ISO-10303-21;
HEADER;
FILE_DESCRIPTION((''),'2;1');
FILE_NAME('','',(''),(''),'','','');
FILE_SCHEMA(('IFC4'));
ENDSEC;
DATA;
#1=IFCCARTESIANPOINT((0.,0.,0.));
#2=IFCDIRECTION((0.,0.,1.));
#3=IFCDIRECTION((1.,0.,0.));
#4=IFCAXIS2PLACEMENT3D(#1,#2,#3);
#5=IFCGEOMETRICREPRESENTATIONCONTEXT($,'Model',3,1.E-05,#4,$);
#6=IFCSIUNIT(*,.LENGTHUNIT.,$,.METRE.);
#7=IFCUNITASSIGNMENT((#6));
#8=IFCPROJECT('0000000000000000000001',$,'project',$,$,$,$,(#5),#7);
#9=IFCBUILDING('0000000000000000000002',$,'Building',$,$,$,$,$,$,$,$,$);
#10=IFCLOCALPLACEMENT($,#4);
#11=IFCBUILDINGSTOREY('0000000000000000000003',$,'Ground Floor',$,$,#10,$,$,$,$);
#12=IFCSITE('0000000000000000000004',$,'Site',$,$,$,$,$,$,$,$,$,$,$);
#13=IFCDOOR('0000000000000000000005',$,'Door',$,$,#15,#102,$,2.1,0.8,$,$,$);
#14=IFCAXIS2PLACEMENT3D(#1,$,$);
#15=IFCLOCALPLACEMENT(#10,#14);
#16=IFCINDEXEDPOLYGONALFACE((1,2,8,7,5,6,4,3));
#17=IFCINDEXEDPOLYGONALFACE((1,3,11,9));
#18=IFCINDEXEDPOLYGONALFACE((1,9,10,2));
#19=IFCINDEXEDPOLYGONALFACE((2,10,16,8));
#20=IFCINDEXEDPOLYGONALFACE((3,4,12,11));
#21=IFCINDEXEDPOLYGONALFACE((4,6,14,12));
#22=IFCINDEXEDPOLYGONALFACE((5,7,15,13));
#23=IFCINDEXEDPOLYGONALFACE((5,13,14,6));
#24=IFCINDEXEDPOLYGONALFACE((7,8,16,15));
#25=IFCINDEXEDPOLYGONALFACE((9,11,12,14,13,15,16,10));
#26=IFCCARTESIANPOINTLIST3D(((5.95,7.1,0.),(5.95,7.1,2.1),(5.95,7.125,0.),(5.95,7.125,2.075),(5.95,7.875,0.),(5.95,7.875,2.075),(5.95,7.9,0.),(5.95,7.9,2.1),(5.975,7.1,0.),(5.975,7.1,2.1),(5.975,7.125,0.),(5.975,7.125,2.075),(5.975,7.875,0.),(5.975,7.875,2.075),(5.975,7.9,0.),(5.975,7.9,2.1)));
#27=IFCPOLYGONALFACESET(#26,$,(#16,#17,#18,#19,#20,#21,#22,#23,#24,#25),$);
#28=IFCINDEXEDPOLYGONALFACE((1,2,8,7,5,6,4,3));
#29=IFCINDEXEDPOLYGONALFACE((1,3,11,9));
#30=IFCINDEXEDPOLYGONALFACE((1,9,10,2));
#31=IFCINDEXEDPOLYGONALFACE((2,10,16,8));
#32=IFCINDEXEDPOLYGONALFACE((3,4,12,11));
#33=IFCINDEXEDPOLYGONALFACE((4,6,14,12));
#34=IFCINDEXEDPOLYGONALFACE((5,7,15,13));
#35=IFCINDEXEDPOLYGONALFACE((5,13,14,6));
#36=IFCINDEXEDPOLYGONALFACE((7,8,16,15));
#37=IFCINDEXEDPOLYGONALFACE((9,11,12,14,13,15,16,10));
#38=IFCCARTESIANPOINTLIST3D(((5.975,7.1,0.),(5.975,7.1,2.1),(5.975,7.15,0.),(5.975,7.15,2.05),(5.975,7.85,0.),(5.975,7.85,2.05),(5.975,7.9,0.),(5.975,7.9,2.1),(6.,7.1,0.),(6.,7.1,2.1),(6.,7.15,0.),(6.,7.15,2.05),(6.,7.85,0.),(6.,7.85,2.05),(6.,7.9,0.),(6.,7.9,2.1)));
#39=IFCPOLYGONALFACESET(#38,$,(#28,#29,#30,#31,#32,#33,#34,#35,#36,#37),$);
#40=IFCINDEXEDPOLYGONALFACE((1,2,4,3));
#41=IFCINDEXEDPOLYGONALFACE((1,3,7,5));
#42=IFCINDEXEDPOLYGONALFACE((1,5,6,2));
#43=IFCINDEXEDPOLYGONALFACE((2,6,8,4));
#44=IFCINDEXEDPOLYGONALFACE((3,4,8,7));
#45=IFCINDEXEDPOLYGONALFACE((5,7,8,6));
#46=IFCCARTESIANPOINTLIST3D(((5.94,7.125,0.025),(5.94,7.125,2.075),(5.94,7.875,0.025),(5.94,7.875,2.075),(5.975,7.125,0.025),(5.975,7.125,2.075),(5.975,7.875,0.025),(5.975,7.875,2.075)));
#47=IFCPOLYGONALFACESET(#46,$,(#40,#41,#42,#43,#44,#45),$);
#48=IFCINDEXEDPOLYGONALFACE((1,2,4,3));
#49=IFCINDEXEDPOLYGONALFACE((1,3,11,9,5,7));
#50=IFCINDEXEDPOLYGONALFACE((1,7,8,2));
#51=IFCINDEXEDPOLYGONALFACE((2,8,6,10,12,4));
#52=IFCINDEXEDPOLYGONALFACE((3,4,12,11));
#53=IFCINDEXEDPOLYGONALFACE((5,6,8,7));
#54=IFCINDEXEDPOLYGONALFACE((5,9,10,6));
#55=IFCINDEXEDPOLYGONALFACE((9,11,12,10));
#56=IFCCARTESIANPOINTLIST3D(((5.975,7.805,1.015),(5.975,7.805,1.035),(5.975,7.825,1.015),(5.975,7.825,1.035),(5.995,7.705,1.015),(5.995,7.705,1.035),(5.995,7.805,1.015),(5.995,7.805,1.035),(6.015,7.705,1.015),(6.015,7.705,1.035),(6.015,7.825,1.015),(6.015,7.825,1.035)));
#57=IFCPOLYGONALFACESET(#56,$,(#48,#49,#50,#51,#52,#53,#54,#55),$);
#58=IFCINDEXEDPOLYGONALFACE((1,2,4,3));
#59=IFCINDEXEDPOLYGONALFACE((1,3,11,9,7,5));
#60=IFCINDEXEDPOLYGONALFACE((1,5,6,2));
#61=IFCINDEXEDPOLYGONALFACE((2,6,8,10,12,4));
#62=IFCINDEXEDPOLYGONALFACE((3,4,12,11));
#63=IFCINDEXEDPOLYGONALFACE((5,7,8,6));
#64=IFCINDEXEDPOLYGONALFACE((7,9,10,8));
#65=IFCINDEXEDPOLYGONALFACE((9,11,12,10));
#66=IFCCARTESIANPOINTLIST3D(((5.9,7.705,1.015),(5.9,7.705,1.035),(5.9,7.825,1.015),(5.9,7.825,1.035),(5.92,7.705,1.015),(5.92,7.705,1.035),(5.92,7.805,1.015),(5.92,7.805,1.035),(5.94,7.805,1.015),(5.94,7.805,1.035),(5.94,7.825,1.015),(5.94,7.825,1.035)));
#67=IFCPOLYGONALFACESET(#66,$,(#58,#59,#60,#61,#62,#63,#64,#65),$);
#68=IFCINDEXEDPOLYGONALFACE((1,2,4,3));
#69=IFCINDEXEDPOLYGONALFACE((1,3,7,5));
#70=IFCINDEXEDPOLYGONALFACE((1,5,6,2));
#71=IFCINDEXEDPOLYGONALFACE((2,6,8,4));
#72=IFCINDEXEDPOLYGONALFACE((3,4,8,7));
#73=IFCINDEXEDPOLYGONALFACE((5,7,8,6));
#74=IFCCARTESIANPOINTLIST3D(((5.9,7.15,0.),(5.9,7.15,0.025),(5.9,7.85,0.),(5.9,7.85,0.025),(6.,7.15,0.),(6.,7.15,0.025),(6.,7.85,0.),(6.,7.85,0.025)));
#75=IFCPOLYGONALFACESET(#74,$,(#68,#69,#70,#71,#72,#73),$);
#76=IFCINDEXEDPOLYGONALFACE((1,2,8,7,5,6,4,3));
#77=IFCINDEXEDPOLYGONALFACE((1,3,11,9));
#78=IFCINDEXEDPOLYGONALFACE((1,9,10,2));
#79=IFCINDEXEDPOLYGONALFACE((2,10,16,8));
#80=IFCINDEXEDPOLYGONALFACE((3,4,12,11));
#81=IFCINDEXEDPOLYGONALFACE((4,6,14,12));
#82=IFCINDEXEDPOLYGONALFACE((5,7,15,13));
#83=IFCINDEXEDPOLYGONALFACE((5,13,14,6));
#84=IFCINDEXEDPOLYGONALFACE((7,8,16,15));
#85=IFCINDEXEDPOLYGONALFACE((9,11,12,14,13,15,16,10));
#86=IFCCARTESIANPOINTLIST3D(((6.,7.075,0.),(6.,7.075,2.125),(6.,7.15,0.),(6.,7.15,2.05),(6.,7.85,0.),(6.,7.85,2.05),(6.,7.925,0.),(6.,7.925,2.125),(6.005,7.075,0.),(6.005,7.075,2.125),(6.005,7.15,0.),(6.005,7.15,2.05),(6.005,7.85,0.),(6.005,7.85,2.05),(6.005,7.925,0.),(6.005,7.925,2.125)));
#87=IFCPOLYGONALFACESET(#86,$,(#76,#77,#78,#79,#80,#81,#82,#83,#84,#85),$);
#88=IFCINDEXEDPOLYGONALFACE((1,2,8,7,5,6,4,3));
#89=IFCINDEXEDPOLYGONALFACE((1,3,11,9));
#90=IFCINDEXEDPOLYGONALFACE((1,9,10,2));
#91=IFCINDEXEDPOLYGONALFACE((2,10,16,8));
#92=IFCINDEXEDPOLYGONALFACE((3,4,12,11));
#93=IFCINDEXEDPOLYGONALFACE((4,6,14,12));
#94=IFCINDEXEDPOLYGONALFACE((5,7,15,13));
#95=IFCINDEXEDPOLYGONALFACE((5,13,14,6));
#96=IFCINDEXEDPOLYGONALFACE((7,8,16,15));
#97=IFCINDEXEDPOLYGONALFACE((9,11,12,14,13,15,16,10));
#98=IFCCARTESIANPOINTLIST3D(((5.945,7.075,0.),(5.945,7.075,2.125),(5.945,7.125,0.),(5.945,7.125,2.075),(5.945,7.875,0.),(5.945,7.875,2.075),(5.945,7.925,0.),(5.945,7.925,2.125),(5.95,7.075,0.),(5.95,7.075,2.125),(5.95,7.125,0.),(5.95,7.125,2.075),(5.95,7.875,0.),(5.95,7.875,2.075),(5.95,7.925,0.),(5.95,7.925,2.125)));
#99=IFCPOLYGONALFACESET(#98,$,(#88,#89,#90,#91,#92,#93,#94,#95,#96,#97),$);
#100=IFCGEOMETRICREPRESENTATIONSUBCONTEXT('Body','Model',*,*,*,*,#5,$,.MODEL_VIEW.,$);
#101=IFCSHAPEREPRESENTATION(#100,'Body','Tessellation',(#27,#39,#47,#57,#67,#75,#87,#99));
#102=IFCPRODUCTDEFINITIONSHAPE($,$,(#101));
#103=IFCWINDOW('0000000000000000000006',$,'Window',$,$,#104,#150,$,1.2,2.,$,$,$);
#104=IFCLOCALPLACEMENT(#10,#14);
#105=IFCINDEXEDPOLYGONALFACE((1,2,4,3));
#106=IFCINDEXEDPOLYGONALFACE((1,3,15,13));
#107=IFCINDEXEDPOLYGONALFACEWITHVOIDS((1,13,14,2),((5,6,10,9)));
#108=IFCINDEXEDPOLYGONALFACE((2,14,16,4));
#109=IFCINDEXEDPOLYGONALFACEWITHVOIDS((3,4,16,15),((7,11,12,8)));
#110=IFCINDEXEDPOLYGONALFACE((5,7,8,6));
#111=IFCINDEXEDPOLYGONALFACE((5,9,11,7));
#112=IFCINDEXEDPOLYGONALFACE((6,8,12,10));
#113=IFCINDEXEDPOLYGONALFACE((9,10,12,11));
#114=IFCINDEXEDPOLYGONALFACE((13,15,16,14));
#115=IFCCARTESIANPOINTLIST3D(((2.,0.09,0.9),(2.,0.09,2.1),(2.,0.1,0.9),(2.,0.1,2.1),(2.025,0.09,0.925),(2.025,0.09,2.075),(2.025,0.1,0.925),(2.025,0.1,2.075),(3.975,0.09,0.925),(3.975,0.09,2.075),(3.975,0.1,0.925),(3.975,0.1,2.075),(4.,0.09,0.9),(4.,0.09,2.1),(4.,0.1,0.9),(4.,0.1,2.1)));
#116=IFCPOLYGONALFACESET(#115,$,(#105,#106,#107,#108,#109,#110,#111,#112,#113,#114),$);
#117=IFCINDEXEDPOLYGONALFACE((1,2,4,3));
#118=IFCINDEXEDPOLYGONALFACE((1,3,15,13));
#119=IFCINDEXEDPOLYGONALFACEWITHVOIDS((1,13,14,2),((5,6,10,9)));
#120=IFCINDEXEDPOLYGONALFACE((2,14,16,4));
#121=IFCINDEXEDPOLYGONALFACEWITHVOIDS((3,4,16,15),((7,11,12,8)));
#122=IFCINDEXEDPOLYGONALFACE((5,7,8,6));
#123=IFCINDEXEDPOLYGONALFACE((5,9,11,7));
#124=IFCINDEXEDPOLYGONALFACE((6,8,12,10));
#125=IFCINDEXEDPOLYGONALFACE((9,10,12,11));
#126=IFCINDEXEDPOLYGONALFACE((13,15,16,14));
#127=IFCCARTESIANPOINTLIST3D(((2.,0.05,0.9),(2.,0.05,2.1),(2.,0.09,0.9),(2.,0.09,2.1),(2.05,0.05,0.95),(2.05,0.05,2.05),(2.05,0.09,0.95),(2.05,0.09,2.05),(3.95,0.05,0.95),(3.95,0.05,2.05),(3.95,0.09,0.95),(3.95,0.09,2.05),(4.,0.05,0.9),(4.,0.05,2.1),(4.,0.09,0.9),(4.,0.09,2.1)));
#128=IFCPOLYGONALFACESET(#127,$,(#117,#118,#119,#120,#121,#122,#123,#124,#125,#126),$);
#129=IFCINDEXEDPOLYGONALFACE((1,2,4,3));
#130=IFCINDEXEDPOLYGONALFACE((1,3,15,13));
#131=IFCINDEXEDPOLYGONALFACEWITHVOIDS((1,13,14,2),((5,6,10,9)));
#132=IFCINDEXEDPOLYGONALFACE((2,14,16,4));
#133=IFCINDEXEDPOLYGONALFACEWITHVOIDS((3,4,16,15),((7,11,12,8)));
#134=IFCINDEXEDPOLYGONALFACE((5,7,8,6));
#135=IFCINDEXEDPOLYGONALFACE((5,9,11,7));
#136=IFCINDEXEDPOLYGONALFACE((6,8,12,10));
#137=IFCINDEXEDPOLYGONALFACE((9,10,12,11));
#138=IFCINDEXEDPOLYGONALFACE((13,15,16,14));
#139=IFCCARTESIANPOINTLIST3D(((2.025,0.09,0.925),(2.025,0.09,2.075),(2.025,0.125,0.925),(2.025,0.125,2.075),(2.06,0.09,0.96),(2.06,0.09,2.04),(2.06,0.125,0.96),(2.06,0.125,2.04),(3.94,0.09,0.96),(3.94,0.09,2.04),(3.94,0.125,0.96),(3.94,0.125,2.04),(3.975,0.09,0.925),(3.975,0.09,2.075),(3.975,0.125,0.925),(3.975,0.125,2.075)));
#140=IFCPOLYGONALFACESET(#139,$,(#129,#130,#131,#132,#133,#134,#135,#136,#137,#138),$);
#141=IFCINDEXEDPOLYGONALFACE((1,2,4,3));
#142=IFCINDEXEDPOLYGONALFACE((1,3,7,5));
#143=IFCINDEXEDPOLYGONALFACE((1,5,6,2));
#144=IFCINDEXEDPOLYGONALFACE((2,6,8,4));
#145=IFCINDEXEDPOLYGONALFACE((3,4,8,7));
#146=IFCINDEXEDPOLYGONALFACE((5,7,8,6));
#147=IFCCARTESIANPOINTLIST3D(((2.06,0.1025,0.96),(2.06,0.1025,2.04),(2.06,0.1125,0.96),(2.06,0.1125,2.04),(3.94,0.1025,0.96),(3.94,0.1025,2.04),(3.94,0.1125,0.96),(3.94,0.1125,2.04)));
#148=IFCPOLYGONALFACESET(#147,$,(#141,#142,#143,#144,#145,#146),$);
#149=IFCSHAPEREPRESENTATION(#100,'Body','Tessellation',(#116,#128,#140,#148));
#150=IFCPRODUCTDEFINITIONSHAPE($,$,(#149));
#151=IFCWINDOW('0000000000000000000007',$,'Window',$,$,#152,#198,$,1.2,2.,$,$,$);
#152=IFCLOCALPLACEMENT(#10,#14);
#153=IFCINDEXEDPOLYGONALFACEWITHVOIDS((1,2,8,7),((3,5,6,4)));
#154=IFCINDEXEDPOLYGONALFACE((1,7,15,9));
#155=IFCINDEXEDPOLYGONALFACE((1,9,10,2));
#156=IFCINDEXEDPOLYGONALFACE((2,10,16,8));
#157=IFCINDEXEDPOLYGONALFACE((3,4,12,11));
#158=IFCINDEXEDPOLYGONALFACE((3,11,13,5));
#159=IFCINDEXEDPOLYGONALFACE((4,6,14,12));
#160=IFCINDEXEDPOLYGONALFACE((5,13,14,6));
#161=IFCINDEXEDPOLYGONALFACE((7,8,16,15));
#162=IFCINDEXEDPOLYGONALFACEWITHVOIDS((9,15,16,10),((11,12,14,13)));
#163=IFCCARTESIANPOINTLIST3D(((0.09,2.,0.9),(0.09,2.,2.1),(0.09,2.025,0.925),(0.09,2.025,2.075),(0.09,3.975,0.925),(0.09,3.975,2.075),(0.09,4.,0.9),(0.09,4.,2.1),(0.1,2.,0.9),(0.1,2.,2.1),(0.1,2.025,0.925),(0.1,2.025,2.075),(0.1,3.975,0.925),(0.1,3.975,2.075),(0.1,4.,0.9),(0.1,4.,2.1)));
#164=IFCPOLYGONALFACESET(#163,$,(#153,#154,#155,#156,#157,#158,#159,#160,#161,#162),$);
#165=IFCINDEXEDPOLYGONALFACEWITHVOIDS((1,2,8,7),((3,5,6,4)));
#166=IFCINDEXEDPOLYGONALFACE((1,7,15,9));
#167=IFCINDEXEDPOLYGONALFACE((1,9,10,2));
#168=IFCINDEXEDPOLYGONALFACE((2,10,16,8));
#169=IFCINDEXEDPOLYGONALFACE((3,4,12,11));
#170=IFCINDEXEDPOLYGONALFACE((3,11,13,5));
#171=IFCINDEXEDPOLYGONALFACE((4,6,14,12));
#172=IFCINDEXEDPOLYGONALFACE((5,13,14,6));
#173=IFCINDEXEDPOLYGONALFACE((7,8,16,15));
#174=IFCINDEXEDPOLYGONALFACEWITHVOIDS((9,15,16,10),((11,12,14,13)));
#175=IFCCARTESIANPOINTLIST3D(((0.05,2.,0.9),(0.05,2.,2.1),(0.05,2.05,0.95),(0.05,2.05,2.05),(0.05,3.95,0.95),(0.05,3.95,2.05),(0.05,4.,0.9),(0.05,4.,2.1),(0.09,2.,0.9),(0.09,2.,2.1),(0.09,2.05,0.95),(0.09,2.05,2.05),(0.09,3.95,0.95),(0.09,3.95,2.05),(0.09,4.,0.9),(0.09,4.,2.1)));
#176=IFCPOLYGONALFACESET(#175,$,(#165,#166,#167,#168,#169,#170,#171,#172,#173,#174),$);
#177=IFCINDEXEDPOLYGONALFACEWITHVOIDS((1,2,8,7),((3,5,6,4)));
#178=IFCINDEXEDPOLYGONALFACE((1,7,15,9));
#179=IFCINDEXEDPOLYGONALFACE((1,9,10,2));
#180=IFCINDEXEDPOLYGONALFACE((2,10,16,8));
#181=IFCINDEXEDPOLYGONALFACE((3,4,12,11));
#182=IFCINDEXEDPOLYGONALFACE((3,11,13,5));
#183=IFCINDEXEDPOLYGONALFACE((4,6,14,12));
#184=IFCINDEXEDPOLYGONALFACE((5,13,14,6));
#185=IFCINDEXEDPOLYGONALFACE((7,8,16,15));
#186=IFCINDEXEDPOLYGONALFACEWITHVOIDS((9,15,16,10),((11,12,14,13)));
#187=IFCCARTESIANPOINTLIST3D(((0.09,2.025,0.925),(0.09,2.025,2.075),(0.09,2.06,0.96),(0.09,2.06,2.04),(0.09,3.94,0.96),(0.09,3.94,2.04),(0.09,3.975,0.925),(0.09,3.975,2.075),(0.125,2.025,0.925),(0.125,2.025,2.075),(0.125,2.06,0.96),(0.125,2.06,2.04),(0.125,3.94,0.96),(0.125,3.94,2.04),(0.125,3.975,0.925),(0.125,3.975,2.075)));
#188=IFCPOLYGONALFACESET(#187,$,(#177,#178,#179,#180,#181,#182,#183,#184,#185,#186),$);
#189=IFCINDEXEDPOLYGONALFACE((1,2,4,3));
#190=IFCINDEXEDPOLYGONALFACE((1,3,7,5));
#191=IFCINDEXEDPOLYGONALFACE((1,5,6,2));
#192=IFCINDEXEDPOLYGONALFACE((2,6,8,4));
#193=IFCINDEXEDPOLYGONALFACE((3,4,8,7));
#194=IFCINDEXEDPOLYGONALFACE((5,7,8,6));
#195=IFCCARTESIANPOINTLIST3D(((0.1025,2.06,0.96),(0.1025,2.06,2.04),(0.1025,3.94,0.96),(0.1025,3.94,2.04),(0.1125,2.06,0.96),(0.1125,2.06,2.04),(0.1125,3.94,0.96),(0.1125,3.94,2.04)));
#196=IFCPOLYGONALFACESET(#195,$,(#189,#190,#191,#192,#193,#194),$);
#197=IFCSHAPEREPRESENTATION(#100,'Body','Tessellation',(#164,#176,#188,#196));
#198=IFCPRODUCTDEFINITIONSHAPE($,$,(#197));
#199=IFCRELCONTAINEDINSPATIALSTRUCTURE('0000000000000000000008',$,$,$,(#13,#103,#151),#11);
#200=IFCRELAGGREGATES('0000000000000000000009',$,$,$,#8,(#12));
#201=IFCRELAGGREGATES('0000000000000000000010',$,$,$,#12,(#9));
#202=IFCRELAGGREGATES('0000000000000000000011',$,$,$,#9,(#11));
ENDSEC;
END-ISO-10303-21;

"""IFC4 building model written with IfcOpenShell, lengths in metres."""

from ifc_helpers import new_model, si_unit, frame, origin_with_axes, place, context, subcontext, project, spatial, line, indexed_curve, outline, extrude, element, save


model = new_model("IFC4")

# Units and contexts
model_context = context("Model", 3, precision=1e-05, world=origin_with_axes())
body_context = subcontext(model_context, "Body", "Model", "MODEL_VIEW")
ifc_project = project(units=[si_unit("LENGTHUNIT", "METRE")], contexts=[model_context])

# Site, building, storey
site = spatial("IfcSite", under=ifc_project, Name="Site")
building = spatial("IfcBuilding", under=site, Name="Building")
storey_placement = place(None, origin_with_axes())
storey = spatial("IfcBuildingStorey", under=building, at=storey_placement, Name="Ground Floor")

# Door
door_1_placement = place(storey_placement, frame((6.0, 7.1, 0.0), z_axis=(0.0, 0.0, 1.0), x_axis=(0.0, 1.0, 0.0)))
element("IfcDoor", 1, at=door_1_placement, inside=storey, Name="Door", OverallHeight=2.1, OverallWidth=0.8, context=body_context, shape_type="SweptSolid", body=[
    extrude(outline(indexed_curve([(0.0, 0.0), (0.0, 2.1), (0.8, 2.1), (0.8, 0.0), (0.775, 0.0), (0.775, 2.075), (0.025, 2.075), (0.025, 0.0)], segments=[line(1, 2, 3, 4, 5, 6, 7, 8, 1)])), frame((0.0, 0.025, 0.0), z_axis=(0.0, -1.0, 0.0), x_axis=(1.0, 0.0, 0.0)), (0.0, 0.0, -1.0), 0.025),
    extrude(outline(indexed_curve([(0.0, 0.0), (0.0, 2.1), (0.8, 2.1), (0.8, 0.0), (0.75, 0.0), (0.75, 2.05), (0.05, 2.05), (0.05, 0.0)], segments=[line(1, 2, 3, 4, 5, 6, 7, 8, 1)])), frame((0.0, 0.0, 0.0), z_axis=(0.0, -1.0, 0.0), x_axis=(1.0, 0.0, 0.0)), (0.0, 0.0, -1.0), 0.025),
    extrude(outline(indexed_curve([(0.0, 0.0), (0.75, 0.0), (0.75, 0.035), (0.0, 0.035)], segments=[line(1, 2, 3, 4, 1)])), frame((0.025, 0.025, 0.025), z_axis=(0.0, 0.0, 1.0), x_axis=(1.0, 0.0, 0.0)), (0.0, 0.0, 1.0), 2.05),
    extrude(outline(indexed_curve([(0.0, 0.0), (0.0, -0.04), (-0.12, -0.04), (-0.12, -0.02), (-0.02, -0.02), (-0.02, 0.0)], segments=[line(1, 2, 3, 4, 5, 6, 1)])), frame((0.725, 0.025, 1.015), z_axis=(0.0, 0.0, 1.0), x_axis=(1.0, 0.0, 0.0)), (0.0, 0.0, 1.0), 0.02),
    extrude(outline(indexed_curve([(0.0, 0.0), (0.0, 0.04), (-0.12, 0.04), (-0.12, 0.02), (-0.02, 0.02), (-0.02, 0.0)], segments=[line(1, 2, 3, 4, 5, 6, 1)])), frame((0.725, 0.06, 1.015), z_axis=(0.0, 0.0, 1.0), x_axis=(1.0, 0.0, 0.0)), (0.0, 0.0, 1.0), 0.02),
    extrude(outline(indexed_curve([(0.0, 0.0), (0.7, 0.0), (0.7, 0.1), (0.0, 0.1)], segments=[line(1, 2, 3, 4, 1)])), frame((0.05, 0.0, 0.0), z_axis=(0.0, 0.0, 1.0), x_axis=(1.0, 0.0, 0.0)), (0.0, 0.0, 1.0), 0.025),
    extrude(outline(indexed_curve([(0.0, 0.0), (0.0, 2.125), (0.85, 2.125), (0.85, 0.0), (0.775, 0.0), (0.775, 2.05), (0.075, 2.05), (0.075, 0.0)], segments=[line(1, 2, 3, 4, 5, 6, 7, 8, 1)])), frame((-0.025, -0.005, 0.0), z_axis=(0.0, -1.0, 0.0), x_axis=(1.0, 0.0, 0.0)), (0.0, 0.0, -1.0), 0.005),
    extrude(outline(indexed_curve([(0.0, 0.0), (0.0, 2.125), (0.85, 2.125), (0.85, 0.0), (0.8, 0.0), (0.8, 2.075), (0.05, 2.075), (0.05, 0.0)], segments=[line(1, 2, 3, 4, 5, 6, 7, 8, 1)])), frame((-0.025, 0.05, 0.0), z_axis=(0.0, -1.0, 0.0), x_axis=(1.0, 0.0, 0.0)), (0.0, 0.0, -1.0), 0.005),
])

# Windows
for number, where, z_axis, x_axis, name in (
    (2, (2.0, 0.0, 0.9), (0.0, 0.0, 1.0), (1.0, 0.0, 0.0), "Window"),
    (3, (0.0, 4.0, 0.9), (0.0, 0.0, 1.0), (0.0, -1.0, 0.0), "Window"),
):
    element("IfcWindow", number, at=place(storey_placement, frame(where, z_axis=z_axis, x_axis=x_axis)), inside=storey, Name=name, OverallHeight=1.2, OverallWidth=2.0, context=body_context, shape_type="SweptSolid", body=[
        extrude(outline(indexed_curve([(0.0, 0.0), (2.0, 0.0), (2.0, 1.2), (0.0, 1.2)], segments=[line(1, 2, 3, 4, 1)]), holes=[indexed_curve([(0.025, 0.025), (1.975, 0.025), (1.975, 1.175), (0.025, 1.175)], segments=[line(1, 2, 3, 4, 1)])]), frame((0.0, 0.09, 0.0), z_axis=(0.0, -1.0, 0.0), x_axis=(1.0, 0.0, 0.0)), (0.0, 0.0, -1.0), 0.01),
        extrude(outline(indexed_curve([(0.0, 0.0), (2.0, 0.0), (2.0, 1.2), (0.0, 1.2)], segments=[line(1, 2, 3, 4, 1)]), holes=[indexed_curve([(0.05, 0.05), (1.95, 0.05), (1.95, 1.15), (0.05, 1.15)], segments=[line(1, 2, 3, 4, 1)])]), frame((0.0, 0.05, 0.0), z_axis=(0.0, -1.0, 0.0), x_axis=(1.0, 0.0, 0.0)), (0.0, 0.0, -1.0), 0.04),
        extrude(outline(indexed_curve([(0.0, 0.0), (1.95, 0.0), (1.95, 1.15), (0.0, 1.15)], segments=[line(1, 2, 3, 4, 1)]), holes=[indexed_curve([(0.035, 0.035), (1.915, 0.035), (1.915, 1.115), (0.035, 1.115)], segments=[line(1, 2, 3, 4, 1)])]), frame((0.025, 0.09, 0.025), z_axis=(0.0, -1.0, 0.0), x_axis=(1.0, 0.0, 0.0)), (0.0, 0.0, -1.0), 0.035),
        extrude(outline(indexed_curve([(0.035, 0.035), (1.915, 0.035), (1.915, 1.115), (0.035, 1.115)], segments=[line(1, 2, 3, 4, 1)])), frame((0.025, 0.1025, 0.025), z_axis=(0.0, -1.0, 0.0), x_axis=(1.0, 0.0, 0.0)), (0.0, 0.0, -1.0), 0.01),
    ])

save(model, "model.ifc")
